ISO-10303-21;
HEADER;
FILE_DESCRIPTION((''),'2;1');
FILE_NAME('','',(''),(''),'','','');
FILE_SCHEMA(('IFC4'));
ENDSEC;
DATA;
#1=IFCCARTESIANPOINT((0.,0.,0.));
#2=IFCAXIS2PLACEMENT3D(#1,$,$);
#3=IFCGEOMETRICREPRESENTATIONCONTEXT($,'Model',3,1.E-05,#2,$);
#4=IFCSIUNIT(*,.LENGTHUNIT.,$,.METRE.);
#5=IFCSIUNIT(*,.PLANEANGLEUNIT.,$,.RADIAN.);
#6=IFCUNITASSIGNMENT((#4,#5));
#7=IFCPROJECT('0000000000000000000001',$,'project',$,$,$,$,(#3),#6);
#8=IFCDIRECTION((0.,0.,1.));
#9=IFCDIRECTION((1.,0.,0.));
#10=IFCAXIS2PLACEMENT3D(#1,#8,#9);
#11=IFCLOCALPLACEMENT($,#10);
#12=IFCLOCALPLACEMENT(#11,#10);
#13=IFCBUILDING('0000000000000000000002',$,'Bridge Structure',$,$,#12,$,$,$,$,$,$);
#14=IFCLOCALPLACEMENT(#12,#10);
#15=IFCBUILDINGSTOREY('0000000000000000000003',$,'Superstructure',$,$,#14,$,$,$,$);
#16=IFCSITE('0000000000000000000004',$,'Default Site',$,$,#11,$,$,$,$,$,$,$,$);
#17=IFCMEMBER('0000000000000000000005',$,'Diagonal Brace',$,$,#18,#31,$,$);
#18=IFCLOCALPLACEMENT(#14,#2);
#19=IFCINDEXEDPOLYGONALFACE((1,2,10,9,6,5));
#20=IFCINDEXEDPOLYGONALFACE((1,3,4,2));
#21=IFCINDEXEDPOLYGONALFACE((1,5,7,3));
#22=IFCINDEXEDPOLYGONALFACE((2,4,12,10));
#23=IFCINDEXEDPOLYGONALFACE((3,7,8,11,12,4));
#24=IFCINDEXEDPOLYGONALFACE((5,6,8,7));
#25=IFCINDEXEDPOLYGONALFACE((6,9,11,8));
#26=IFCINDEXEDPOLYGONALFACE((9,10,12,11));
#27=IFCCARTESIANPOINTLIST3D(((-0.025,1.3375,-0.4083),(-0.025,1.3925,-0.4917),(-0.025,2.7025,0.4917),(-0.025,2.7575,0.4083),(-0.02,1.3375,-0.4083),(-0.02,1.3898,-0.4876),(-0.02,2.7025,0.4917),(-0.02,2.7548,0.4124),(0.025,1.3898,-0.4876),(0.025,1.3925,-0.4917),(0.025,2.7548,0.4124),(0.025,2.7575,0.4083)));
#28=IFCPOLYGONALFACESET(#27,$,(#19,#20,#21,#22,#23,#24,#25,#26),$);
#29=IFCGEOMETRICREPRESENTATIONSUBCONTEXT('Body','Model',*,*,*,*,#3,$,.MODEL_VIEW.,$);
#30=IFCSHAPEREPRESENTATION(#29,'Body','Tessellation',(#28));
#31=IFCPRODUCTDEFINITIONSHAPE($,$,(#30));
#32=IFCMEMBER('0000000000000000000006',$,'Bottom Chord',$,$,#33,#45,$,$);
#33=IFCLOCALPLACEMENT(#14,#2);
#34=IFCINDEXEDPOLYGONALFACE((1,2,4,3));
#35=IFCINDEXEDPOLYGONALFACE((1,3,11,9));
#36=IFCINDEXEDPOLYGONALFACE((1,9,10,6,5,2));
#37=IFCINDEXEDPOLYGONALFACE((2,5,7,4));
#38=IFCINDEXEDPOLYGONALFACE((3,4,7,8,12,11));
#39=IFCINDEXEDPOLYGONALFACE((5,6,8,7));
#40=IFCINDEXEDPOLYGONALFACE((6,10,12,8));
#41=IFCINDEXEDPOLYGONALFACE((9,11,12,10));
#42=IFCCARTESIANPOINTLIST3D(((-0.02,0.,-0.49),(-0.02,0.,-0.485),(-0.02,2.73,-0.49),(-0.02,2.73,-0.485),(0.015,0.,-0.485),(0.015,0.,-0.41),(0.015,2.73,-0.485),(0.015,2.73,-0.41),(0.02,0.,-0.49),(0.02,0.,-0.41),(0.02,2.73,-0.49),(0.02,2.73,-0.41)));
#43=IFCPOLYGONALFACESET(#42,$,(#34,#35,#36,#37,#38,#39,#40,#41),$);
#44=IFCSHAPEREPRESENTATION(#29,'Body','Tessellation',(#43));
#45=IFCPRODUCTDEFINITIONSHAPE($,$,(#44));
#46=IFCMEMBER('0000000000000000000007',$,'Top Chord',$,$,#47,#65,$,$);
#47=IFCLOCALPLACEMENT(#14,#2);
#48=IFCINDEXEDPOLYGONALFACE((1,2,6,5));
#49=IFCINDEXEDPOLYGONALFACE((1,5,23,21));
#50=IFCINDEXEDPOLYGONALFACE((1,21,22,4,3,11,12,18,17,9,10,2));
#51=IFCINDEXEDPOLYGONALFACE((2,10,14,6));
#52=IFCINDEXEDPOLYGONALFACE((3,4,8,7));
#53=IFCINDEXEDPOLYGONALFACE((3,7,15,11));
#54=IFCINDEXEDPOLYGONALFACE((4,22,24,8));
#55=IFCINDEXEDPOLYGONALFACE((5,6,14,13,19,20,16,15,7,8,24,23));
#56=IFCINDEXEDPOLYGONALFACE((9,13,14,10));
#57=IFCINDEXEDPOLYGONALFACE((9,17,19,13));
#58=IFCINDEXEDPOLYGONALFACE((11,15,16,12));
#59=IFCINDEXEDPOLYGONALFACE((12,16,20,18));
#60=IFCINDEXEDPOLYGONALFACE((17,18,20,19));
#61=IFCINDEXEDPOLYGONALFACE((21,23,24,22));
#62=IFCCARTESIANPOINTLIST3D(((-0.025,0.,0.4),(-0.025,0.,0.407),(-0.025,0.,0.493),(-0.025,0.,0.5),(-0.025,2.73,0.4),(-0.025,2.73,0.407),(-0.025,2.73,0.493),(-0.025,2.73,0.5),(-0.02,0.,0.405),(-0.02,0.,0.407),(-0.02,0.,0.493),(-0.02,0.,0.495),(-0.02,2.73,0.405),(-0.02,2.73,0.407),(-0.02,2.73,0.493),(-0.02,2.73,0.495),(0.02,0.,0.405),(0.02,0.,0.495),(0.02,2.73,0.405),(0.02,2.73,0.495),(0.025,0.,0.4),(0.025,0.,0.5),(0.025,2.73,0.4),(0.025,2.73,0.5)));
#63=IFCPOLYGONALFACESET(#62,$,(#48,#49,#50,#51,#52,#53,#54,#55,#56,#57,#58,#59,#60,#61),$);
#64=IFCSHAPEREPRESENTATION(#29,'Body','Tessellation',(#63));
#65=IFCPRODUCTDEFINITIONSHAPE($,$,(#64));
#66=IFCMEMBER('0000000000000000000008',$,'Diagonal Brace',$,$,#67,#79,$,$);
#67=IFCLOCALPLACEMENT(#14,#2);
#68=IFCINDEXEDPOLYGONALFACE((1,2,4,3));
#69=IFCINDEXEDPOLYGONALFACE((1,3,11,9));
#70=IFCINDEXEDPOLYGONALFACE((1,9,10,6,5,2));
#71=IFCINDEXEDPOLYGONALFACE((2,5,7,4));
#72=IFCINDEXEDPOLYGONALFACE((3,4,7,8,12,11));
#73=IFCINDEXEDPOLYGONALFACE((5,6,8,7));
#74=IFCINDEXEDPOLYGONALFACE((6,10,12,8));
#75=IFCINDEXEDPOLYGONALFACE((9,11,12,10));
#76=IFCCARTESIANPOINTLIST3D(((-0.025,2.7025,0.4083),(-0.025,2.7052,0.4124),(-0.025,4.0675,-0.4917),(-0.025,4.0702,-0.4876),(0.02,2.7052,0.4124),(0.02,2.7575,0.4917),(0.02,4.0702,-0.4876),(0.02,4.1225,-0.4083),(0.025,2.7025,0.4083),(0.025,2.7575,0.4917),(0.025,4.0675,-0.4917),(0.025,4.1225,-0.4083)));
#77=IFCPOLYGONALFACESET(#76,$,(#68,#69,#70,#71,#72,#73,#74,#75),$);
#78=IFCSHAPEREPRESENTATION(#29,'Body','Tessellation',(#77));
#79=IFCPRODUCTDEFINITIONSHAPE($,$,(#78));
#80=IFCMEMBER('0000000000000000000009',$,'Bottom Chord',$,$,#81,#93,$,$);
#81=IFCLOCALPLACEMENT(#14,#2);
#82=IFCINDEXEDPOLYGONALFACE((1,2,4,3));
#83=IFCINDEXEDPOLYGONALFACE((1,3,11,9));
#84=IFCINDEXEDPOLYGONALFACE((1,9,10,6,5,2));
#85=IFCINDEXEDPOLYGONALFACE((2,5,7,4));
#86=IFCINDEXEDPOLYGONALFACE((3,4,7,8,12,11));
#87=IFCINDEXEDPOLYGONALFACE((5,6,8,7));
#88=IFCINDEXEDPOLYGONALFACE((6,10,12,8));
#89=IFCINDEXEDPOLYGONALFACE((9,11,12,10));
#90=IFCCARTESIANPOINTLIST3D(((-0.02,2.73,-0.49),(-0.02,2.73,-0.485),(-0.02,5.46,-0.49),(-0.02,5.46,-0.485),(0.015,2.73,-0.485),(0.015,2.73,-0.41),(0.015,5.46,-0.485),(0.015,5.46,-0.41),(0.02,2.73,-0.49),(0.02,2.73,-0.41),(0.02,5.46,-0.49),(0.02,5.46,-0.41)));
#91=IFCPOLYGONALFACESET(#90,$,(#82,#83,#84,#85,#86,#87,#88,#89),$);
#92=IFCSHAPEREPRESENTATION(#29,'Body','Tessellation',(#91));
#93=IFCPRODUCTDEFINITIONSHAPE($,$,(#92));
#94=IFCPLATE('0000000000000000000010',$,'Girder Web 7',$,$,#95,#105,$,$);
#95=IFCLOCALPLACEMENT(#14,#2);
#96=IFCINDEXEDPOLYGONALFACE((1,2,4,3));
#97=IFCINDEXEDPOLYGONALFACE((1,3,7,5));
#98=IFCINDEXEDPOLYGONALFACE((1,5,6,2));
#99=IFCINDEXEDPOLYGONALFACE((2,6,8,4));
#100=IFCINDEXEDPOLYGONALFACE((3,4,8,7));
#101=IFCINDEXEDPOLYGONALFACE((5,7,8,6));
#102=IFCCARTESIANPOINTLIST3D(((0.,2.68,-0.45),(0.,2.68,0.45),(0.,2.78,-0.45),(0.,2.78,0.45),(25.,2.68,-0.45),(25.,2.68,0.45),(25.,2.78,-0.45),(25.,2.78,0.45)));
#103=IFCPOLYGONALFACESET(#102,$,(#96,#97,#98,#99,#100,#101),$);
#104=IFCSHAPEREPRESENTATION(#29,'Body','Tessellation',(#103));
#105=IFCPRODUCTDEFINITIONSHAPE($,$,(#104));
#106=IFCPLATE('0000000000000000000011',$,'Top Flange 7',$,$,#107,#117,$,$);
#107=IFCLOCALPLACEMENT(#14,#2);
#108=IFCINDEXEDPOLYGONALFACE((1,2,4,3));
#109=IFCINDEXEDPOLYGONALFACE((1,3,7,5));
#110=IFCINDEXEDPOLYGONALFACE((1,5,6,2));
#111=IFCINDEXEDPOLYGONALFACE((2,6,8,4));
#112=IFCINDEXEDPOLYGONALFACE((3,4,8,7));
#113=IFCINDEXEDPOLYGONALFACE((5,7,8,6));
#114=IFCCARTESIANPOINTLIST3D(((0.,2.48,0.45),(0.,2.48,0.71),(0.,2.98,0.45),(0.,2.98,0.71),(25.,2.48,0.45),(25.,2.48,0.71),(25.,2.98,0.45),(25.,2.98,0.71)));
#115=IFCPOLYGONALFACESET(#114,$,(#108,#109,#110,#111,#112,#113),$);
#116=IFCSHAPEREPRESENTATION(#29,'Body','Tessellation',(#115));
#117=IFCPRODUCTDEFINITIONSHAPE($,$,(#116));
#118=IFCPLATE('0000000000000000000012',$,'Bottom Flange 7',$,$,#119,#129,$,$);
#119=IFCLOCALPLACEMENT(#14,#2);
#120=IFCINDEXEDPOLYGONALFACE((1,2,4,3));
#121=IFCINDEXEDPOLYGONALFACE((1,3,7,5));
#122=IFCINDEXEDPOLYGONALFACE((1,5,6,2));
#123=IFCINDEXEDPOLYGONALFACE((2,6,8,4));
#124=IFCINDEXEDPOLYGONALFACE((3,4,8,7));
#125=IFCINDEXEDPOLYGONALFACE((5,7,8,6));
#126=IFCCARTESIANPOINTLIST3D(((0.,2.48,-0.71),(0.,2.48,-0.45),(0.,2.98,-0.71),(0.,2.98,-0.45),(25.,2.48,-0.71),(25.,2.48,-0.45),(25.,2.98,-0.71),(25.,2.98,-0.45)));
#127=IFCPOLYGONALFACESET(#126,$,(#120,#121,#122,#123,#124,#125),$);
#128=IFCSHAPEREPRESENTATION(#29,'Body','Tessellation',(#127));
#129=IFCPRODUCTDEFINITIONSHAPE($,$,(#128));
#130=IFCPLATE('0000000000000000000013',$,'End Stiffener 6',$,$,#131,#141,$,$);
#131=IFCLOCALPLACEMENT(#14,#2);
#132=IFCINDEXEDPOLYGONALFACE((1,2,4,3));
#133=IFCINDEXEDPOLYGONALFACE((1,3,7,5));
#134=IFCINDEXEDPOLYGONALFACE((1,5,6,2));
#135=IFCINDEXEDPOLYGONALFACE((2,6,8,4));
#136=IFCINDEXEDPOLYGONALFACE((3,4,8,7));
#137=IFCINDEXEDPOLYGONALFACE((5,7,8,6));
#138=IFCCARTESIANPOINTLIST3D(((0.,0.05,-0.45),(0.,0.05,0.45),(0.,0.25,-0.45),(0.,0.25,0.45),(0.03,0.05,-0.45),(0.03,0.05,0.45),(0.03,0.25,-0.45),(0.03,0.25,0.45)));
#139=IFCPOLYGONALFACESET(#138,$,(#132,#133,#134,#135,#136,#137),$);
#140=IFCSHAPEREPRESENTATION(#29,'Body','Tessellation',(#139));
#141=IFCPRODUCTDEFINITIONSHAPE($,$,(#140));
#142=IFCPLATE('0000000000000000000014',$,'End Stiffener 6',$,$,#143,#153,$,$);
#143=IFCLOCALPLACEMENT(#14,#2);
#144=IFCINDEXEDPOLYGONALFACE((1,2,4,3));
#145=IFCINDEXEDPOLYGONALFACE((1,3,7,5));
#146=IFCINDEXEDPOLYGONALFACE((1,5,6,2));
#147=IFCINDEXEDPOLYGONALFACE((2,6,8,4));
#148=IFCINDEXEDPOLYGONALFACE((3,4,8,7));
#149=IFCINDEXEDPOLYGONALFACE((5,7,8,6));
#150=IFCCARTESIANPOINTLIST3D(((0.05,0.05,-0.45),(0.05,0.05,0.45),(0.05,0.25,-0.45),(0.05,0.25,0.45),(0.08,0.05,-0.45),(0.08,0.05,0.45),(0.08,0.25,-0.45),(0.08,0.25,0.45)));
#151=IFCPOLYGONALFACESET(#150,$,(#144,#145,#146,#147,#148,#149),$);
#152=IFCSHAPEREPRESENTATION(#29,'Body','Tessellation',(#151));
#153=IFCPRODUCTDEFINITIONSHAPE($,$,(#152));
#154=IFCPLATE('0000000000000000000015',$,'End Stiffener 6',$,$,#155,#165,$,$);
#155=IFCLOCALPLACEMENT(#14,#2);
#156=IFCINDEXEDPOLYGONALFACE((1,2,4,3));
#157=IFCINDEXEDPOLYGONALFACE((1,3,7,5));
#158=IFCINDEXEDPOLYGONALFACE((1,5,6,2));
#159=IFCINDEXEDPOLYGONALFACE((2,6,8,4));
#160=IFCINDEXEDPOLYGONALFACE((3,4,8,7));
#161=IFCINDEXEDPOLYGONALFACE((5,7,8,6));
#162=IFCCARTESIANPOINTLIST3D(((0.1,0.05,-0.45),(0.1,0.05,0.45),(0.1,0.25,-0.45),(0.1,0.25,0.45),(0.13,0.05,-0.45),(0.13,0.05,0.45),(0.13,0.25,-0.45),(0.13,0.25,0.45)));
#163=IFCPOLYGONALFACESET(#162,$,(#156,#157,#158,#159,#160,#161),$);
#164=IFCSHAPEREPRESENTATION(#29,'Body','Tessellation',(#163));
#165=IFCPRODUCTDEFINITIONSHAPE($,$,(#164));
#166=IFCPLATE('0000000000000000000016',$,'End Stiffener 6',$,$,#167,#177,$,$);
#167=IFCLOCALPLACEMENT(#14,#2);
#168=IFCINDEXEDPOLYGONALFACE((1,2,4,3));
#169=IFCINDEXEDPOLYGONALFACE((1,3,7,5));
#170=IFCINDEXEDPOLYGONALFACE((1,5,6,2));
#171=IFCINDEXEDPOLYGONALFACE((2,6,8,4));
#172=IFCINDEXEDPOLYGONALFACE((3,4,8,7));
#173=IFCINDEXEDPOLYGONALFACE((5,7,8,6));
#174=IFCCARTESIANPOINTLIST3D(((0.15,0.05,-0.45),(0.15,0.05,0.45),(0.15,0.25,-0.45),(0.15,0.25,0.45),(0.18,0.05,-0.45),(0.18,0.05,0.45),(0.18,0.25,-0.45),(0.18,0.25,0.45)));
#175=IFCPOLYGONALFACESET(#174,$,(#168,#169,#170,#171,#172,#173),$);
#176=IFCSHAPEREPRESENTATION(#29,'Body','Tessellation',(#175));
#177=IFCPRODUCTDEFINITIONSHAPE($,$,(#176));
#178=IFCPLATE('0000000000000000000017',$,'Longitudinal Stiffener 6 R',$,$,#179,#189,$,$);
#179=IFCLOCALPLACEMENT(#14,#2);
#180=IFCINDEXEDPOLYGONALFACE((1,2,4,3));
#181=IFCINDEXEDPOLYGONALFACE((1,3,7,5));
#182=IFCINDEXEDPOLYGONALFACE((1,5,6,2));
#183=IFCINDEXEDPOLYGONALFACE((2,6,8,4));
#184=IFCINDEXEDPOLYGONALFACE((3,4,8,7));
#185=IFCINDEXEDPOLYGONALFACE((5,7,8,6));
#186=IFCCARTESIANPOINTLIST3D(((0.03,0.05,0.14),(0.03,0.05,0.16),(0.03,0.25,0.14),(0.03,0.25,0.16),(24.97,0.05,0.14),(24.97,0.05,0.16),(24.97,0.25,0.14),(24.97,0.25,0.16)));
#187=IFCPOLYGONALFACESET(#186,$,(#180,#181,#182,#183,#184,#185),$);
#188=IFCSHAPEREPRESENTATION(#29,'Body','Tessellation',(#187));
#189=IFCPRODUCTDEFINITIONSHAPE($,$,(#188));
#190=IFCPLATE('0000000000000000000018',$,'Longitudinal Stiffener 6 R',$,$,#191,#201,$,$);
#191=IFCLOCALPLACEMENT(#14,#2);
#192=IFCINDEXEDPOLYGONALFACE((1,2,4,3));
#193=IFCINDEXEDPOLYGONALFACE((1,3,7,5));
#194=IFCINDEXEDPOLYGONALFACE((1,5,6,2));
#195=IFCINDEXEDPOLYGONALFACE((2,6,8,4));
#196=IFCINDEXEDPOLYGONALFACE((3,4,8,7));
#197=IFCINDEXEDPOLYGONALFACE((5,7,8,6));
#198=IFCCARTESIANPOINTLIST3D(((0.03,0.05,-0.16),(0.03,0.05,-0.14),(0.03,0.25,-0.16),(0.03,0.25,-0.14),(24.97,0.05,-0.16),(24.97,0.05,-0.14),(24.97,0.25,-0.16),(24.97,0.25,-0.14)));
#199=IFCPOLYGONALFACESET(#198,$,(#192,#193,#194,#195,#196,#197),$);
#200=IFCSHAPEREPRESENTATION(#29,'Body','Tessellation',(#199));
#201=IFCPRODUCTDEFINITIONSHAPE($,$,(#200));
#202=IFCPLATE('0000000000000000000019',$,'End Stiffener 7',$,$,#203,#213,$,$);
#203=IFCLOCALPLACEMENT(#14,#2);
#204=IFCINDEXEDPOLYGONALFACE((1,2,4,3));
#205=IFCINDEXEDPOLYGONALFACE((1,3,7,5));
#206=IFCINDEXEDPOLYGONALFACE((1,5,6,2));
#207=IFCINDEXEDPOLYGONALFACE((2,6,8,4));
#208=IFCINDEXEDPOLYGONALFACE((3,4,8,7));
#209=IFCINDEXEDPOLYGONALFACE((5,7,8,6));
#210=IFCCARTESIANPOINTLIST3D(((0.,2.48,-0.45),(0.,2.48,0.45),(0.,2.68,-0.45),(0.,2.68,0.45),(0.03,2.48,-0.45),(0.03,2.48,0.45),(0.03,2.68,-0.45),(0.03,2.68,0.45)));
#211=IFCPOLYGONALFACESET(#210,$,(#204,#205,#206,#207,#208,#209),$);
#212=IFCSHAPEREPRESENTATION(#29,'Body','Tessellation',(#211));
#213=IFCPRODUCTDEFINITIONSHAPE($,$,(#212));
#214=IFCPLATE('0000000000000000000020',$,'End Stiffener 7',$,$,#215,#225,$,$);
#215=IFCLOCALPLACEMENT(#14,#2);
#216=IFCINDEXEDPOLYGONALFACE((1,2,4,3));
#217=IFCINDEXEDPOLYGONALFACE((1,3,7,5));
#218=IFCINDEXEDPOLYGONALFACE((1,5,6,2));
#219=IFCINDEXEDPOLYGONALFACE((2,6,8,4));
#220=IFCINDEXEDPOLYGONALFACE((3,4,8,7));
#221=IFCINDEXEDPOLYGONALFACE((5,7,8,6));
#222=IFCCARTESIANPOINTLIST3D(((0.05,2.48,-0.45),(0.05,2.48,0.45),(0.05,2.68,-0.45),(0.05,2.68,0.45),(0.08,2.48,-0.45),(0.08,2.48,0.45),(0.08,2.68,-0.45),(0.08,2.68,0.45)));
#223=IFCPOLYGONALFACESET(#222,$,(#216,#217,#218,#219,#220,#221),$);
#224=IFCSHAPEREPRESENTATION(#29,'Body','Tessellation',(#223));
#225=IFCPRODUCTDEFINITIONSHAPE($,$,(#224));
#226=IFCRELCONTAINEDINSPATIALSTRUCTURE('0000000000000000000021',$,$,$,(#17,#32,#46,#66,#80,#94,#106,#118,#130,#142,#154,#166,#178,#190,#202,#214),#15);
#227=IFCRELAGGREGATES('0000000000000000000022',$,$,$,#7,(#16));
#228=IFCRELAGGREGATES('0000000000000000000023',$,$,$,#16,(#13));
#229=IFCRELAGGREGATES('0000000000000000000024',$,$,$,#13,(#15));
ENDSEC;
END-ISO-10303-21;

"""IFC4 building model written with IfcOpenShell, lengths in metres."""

from ifc_helpers import new_model, si_unit, frame, origin, origin_with_axes, origin_2d_with_axis, place, context, subcontext, project, spatial, rectangle, l_section, c_section, extrude, element, save


model = new_model("IFC4")

# Units and contexts
model_context = context("Model", 3, precision=1e-05, world=origin())
body_context = subcontext(model_context, "Body", "Model", "MODEL_VIEW")
ifc_project = project(units=[si_unit("LENGTHUNIT", "METRE"), si_unit("PLANEANGLEUNIT", "RADIAN")], contexts=[model_context])

# Site, building, storey
site_placement = place(None, origin_with_axes())
site = spatial("IfcSite", under=ifc_project, at=site_placement, Name="Default Site")
building_placement = place(site_placement, origin_with_axes())
building = spatial("IfcBuilding", under=site, at=building_placement, Name="Bridge Structure")
storey_placement = place(building_placement, origin_with_axes())
storey = spatial("IfcBuildingStorey", under=building, at=storey_placement, Name="Superstructure")

# Members
member_1_placement = place(storey_placement, frame((0.0, 2.73, 0.45), z_axis=(0.0, -0.834862, -0.550459), x_axis=(1.0, 0.0, 0.0)))
element("IfcMember", 1, at=member_1_placement, inside=storey, Name="Diagonal Brace", context=body_context, shape_type="SweptSolid", body=[
    extrude(l_section(Depth=0.1, Width=0.05, Thickness=0.005, at=origin_2d_with_axis()), origin_with_axes(), (0.0, 0.0, 1.0), 1.635),
])
member_2_placement = place(storey_placement, frame((0.0, 0.0, -0.45), z_axis=(0.0, 1.0, 0.0), x_axis=(-1.0, 0.0, 0.0)))
element("IfcMember", 2, at=member_2_placement, inside=storey, Name="Bottom Chord", context=body_context, shape_type="SweptSolid", body=[
    extrude(l_section(Depth=0.08, Width=0.04, Thickness=0.005, at=origin_2d_with_axis()), origin_with_axes(), (0.0, 0.0, 1.0), 2.73),
])
member_3_placement = place(storey_placement, frame((0.0, 0.0, 0.45), z_axis=(0.0, 1.0, 0.0), x_axis=(-1.0, 0.0, 0.0)))
element("IfcMember", 3, at=member_3_placement, inside=storey, Name="Top Chord", context=body_context, shape_type="SweptSolid", body=[
    extrude(c_section(Depth=0.1, Width=0.05, WallThickness=0.005, Girth=0.007, at=origin_2d_with_axis()), origin_with_axes(), (0.0, 0.0, 1.0), 2.73),
])
member_4_placement = place(storey_placement, frame((0.0, 2.73, 0.45), z_axis=(0.0, 0.834862, -0.550459), x_axis=(-1.0, 0.0, 0.0)))
element("IfcMember", 4, at=member_4_placement, inside=storey, Name="Diagonal Brace", context=body_context, shape_type="SweptSolid", body=[
    extrude(l_section(Depth=0.1, Width=0.05, Thickness=0.005, at=origin_2d_with_axis()), origin_with_axes(), (0.0, 0.0, 1.0), 1.635),
])
member_5_placement = place(storey_placement, frame((0.0, 2.73, -0.45), z_axis=(0.0, 1.0, 0.0), x_axis=(-1.0, 0.0, 0.0)))
element("IfcMember", 5, at=member_5_placement, inside=storey, Name="Bottom Chord", context=body_context, shape_type="SweptSolid", body=[
    extrude(l_section(Depth=0.08, Width=0.04, Thickness=0.005, at=origin_2d_with_axis()), origin_with_axes(), (0.0, 0.0, 1.0), 2.73),
])

# Plates
plate_placement = place(storey_placement, frame((0.0, 2.73, 0.0), z_axis=(1.0, 0.0, 0.0), x_axis=(0.0, 1.0, 0.0)))
element("IfcPlate", 6, at=plate_placement, inside=storey, Name="Girder Web 7", context=body_context, shape_type="SweptSolid", body=[
    extrude(rectangle(XDim=0.1, YDim=0.9, at=origin_2d_with_axis()), origin_with_axes(), (0.0, 0.0, 1.0), 25.0),
])
for number, where, z_axis, x_axis, name in (
    (7, (0.0, 2.73, 0.58), (1.0, 0.0, 0.0), (0.0, 1.0, 0.0), "Top Flange 7"),
    (8, (0.0, 2.73, -0.58), (1.0, 0.0, 0.0), (0.0, 1.0, 0.0), "Bottom Flange 7"),
):
    element("IfcPlate", number, at=place(storey_placement, frame(where, z_axis=z_axis, x_axis=x_axis)), inside=storey, Name=name, context=body_context, shape_type="SweptSolid", body=[
        extrude(rectangle(XDim=0.5, YDim=0.26, at=origin_2d_with_axis()), origin_with_axes(), (0.0, 0.0, 1.0), 25.0),
    ])
for number, where, z_axis, x_axis, name in (
    (9, (0.015, 0.15, -0.45), (0.0, 0.0, 1.0), (1.0, 0.0, 0.0), "End Stiffener 6"),
    (10, (0.065, 0.15, -0.45), (0.0, 0.0, 1.0), (1.0, 0.0, 0.0), "End Stiffener 6"),
    (11, (0.115, 0.15, -0.45), (0.0, 0.0, 1.0), (1.0, 0.0, 0.0), "End Stiffener 6"),
    (12, (0.165, 0.15, -0.45), (0.0, 0.0, 1.0), (1.0, 0.0, 0.0), "End Stiffener 6"),
):
    element("IfcPlate", number, at=place(storey_placement, frame(where, z_axis=z_axis, x_axis=x_axis)), inside=storey, Name=name, context=body_context, shape_type="SweptSolid", body=[
        extrude(rectangle(XDim=0.03, YDim=0.2, at=origin_2d_with_axis()), origin_with_axes(), (0.0, 0.0, 1.0), 0.9),
    ])
for number, where, z_axis, x_axis, name in (
    (13, (0.03, 0.15, 0.15), (1.0, 0.0, 0.0), (0.0, 1.0, 0.0), "Longitudinal Stiffener 6 R"),
    (14, (0.03, 0.15, -0.15), (1.0, 0.0, 0.0), (0.0, 1.0, 0.0), "Longitudinal Stiffener 6 R"),
):
    element("IfcPlate", number, at=place(storey_placement, frame(where, z_axis=z_axis, x_axis=x_axis)), inside=storey, Name=name, context=body_context, shape_type="SweptSolid", body=[
        extrude(rectangle(XDim=0.2, YDim=0.02, at=origin_2d_with_axis()), origin_with_axes(), (0.0, 0.0, 1.0), 24.94),
    ])
for number, where, z_axis, x_axis, name in (
    (15, (0.015, 2.58, -0.45), (0.0, 0.0, 1.0), (1.0, 0.0, 0.0), "End Stiffener 7"),
    (16, (0.065, 2.58, -0.45), (0.0, 0.0, 1.0), (1.0, 0.0, 0.0), "End Stiffener 7"),
):
    element("IfcPlate", number, at=place(storey_placement, frame(where, z_axis=z_axis, x_axis=x_axis)), inside=storey, Name=name, context=body_context, shape_type="SweptSolid", body=[
        extrude(rectangle(XDim=0.03, YDim=0.2, at=origin_2d_with_axis()), origin_with_axes(), (0.0, 0.0, 1.0), 0.9),
    ])

save(model, "model.ifc")
